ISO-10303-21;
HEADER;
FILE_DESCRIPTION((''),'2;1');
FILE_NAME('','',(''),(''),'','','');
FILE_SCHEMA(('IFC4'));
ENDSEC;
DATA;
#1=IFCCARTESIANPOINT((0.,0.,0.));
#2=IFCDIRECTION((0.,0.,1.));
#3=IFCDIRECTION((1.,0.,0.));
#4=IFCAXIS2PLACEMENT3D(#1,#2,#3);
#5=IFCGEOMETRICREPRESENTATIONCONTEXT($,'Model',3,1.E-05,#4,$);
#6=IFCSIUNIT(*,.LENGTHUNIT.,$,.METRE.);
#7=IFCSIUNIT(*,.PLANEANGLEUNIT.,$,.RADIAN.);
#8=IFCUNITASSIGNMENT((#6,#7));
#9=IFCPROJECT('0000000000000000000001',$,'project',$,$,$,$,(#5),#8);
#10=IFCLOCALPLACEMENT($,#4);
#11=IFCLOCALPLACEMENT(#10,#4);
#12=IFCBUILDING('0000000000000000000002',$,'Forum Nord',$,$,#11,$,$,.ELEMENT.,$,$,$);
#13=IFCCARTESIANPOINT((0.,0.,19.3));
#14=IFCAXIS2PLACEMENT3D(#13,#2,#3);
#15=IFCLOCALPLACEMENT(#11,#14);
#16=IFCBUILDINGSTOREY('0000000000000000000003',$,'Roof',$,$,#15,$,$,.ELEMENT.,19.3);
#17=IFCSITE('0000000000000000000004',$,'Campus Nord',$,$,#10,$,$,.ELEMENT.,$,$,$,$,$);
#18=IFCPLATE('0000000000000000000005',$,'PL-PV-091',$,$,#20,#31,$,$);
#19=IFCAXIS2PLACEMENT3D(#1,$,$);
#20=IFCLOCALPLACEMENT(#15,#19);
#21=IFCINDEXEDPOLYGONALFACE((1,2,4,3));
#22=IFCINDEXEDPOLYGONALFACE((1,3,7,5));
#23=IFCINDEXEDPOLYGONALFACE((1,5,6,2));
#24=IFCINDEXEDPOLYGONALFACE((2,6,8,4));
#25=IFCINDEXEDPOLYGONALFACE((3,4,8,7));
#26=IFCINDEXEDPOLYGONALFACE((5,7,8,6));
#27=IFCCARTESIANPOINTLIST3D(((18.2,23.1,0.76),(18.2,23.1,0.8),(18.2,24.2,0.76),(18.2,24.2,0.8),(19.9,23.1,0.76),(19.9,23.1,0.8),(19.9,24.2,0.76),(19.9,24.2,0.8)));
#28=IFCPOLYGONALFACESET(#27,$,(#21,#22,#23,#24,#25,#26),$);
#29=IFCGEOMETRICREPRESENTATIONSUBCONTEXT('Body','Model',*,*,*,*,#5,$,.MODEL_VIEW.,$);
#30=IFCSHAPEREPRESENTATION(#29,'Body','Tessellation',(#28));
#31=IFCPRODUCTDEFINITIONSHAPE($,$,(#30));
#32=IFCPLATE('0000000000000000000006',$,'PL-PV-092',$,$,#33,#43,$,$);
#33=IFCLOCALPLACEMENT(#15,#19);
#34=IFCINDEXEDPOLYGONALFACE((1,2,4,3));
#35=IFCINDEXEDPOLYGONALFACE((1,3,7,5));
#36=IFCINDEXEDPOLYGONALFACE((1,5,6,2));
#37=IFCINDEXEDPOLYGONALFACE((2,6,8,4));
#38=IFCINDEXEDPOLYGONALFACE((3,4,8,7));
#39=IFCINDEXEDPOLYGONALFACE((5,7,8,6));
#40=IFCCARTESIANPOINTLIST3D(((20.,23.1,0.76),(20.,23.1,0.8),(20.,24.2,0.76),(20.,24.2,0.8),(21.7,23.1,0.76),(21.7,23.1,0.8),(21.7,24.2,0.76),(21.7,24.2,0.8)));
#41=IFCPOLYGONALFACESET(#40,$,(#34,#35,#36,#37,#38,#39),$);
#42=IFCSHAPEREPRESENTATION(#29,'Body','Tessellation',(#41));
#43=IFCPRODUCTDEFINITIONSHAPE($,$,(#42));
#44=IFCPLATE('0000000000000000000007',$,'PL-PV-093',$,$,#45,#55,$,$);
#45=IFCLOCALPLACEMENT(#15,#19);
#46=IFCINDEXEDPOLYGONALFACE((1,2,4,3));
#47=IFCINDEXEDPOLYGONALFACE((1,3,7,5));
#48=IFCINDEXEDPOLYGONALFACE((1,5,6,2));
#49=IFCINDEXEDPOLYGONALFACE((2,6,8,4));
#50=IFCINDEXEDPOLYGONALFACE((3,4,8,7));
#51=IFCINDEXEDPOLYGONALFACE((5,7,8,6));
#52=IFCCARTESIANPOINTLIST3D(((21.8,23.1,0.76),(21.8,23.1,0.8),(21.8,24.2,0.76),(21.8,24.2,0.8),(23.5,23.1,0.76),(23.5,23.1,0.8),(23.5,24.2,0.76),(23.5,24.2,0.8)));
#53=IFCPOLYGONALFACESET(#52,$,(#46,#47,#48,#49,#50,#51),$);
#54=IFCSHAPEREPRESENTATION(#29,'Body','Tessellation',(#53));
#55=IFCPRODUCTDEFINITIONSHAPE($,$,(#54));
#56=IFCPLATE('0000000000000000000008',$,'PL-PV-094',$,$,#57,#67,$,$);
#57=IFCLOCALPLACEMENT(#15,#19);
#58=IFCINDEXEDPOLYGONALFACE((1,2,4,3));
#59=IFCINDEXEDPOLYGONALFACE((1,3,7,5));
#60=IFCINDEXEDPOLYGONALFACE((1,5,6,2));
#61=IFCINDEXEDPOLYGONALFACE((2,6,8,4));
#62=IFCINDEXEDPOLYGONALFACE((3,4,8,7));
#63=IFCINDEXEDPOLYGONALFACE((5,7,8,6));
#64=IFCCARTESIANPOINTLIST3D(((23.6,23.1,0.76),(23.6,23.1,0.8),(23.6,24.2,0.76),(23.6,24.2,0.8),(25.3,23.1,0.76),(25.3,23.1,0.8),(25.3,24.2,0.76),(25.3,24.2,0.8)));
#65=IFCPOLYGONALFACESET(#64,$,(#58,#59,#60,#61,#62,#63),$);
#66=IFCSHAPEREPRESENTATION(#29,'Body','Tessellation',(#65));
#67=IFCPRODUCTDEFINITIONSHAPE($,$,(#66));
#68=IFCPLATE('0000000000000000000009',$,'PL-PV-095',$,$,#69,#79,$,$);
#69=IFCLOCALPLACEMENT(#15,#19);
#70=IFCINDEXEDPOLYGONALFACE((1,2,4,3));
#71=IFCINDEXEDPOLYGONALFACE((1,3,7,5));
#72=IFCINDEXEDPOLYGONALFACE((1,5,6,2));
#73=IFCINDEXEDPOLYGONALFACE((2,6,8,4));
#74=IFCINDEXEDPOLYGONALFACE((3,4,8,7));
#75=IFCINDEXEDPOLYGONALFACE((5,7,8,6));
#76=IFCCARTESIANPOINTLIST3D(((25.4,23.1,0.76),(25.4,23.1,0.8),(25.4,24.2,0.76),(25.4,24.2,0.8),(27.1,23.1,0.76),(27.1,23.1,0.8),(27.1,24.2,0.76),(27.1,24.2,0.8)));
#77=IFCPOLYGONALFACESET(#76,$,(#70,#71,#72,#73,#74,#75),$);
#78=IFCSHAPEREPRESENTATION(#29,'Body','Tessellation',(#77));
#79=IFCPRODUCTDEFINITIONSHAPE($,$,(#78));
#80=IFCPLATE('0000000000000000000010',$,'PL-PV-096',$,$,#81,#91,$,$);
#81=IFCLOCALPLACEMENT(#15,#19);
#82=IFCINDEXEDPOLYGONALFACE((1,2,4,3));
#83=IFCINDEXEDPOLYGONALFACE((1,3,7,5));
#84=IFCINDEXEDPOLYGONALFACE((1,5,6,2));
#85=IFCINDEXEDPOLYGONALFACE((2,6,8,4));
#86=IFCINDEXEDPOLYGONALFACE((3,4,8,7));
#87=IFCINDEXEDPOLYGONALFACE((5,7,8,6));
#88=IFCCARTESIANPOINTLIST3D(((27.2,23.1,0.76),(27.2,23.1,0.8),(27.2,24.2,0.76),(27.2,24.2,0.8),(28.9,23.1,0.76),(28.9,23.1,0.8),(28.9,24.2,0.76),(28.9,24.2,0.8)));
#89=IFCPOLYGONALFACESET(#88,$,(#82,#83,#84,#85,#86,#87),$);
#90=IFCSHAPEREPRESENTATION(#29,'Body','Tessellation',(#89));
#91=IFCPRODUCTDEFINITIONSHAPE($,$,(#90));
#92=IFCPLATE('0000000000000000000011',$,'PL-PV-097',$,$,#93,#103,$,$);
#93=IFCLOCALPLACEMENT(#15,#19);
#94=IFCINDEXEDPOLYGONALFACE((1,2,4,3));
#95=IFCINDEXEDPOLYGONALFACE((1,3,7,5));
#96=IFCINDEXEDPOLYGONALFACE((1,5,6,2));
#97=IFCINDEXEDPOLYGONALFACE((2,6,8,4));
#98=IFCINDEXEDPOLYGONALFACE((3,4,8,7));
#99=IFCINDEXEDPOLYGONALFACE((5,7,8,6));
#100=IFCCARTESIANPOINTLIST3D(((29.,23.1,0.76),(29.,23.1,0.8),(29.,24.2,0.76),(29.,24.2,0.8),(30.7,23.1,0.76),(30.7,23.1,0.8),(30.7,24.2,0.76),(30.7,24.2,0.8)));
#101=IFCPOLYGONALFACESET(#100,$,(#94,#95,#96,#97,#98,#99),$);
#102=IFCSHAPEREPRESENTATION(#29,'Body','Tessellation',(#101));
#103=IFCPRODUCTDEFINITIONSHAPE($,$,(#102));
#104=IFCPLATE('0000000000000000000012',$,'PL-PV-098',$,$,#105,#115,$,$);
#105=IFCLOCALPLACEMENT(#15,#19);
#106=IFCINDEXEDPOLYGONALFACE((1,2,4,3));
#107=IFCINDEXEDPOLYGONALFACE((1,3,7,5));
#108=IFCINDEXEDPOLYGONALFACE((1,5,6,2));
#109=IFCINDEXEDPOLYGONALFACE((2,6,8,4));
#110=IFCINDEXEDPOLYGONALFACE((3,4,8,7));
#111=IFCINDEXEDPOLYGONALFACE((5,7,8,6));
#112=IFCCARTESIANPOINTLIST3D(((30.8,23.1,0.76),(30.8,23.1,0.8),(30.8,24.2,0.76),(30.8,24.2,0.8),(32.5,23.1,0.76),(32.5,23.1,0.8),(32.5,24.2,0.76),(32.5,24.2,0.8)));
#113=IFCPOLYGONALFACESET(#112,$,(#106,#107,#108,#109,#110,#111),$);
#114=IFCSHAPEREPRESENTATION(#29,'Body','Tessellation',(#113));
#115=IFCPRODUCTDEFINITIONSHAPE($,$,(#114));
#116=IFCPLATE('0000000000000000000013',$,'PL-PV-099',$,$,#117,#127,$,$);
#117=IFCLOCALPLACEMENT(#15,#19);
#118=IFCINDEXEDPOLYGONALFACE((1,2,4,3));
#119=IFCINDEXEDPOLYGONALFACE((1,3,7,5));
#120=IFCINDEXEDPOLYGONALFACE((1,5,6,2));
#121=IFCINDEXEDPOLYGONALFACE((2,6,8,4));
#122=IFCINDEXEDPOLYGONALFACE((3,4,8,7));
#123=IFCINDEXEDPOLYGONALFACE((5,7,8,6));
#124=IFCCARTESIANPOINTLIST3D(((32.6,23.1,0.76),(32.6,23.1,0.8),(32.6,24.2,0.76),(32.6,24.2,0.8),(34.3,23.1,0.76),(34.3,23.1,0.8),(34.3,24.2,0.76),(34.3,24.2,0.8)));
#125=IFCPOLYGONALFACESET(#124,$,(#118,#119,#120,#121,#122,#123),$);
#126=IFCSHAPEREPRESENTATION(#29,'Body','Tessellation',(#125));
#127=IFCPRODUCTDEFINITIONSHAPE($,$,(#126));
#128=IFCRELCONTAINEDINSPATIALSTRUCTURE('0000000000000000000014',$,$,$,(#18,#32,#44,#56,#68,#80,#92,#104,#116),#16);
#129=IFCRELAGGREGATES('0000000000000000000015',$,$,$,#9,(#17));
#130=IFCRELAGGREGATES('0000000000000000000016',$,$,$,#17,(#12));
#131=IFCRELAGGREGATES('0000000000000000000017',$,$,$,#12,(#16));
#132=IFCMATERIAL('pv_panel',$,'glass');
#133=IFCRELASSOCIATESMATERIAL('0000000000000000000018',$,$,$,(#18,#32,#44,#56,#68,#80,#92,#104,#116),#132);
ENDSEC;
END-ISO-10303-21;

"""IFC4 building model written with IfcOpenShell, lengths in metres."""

from ifc_helpers import new_model, si_unit, frame, origin_with_axes, place, context, subcontext, project, spatial, polyline, outline, extrude, material, element, save


model = new_model("IFC4")

# Units and contexts
model_context = context("Model", 3, precision=1e-05, world=origin_with_axes())
body_context = subcontext(model_context, "Body", "Model", "MODEL_VIEW")
ifc_project = project(units=[si_unit("LENGTHUNIT", "METRE"), si_unit("PLANEANGLEUNIT", "RADIAN")], contexts=[model_context])

# Site, building, storey
site_placement = place(None, origin_with_axes())
site = spatial("IfcSite", under=ifc_project, at=site_placement, Name="Campus Nord", CompositionType="ELEMENT")
building_placement = place(site_placement, origin_with_axes())
building = spatial("IfcBuilding", under=site, at=building_placement, Name="Forum Nord", CompositionType="ELEMENT")
storey_placement = place(building_placement, frame((0.0, 0.0, 19.3), z_axis=(0.0, 0.0, 1.0), x_axis=(1.0, 0.0, 0.0)))
storey = spatial("IfcBuildingStorey", under=building, at=storey_placement, Name="Roof", CompositionType="ELEMENT", Elevation=19.3)

# Plates
ifc_material_1 = material(Name="pv_panel", Category="glass")
plate_1_placement = place(storey_placement, frame((0.0, 0.0, 0.8), z_axis=(0.0, 0.0, 1.0), x_axis=(1.0, 0.0, 0.0)))
element("IfcPlate", 1, at=plate_1_placement, inside=storey, material=ifc_material_1, Name="PL-PV-091", context=body_context, shape_type="SweptSolid", body=[
    extrude(outline(polyline([(18.2, 23.1), (19.9, 23.1), (19.9, 24.2), (18.2, 24.2), (18.2, 23.1)])), frame((0.0, 0.0, -0.04), z_axis=(0.0, 0.0, 1.0), x_axis=(1.0, 0.0, 0.0)), (0.0, 0.0, 1.0), 0.04),
])
plate_2_placement = place(storey_placement, frame((0.0, 0.0, 0.8), z_axis=(0.0, 0.0, 1.0), x_axis=(1.0, 0.0, 0.0)))
element("IfcPlate", 2, at=plate_2_placement, inside=storey, material=ifc_material_1, Name="PL-PV-092", context=body_context, shape_type="SweptSolid", body=[
    extrude(outline(polyline([(20.0, 23.1), (21.7, 23.1), (21.7, 24.2), (20.0, 24.2), (20.0, 23.1)])), frame((0.0, 0.0, -0.04), z_axis=(0.0, 0.0, 1.0), x_axis=(1.0, 0.0, 0.0)), (0.0, 0.0, 1.0), 0.04),
])
plate_3_placement = place(storey_placement, frame((0.0, 0.0, 0.8), z_axis=(0.0, 0.0, 1.0), x_axis=(1.0, 0.0, 0.0)))
element("IfcPlate", 3, at=plate_3_placement, inside=storey, material=ifc_material_1, Name="PL-PV-093", context=body_context, shape_type="SweptSolid", body=[
    extrude(outline(polyline([(21.8, 23.1), (23.5, 23.1), (23.5, 24.2), (21.8, 24.2), (21.8, 23.1)])), frame((0.0, 0.0, -0.04), z_axis=(0.0, 0.0, 1.0), x_axis=(1.0, 0.0, 0.0)), (0.0, 0.0, 1.0), 0.04),
])
plate_4_placement = place(storey_placement, frame((0.0, 0.0, 0.8), z_axis=(0.0, 0.0, 1.0), x_axis=(1.0, 0.0, 0.0)))
element("IfcPlate", 4, at=plate_4_placement, inside=storey, material=ifc_material_1, Name="PL-PV-094", context=body_context, shape_type="SweptSolid", body=[
    extrude(outline(polyline([(23.6, 23.1), (25.3, 23.1), (25.3, 24.2), (23.6, 24.2), (23.6, 23.1)])), frame((0.0, 0.0, -0.04), z_axis=(0.0, 0.0, 1.0), x_axis=(1.0, 0.0, 0.0)), (0.0, 0.0, 1.0), 0.04),
])
plate_5_placement = place(storey_placement, frame((0.0, 0.0, 0.8), z_axis=(0.0, 0.0, 1.0), x_axis=(1.0, 0.0, 0.0)))
element("IfcPlate", 5, at=plate_5_placement, inside=storey, material=ifc_material_1, Name="PL-PV-095", context=body_context, shape_type="SweptSolid", body=[
    extrude(outline(polyline([(25.4, 23.1), (27.1, 23.1), (27.1, 24.2), (25.4, 24.2), (25.4, 23.1)])), frame((0.0, 0.0, -0.04), z_axis=(0.0, 0.0, 1.0), x_axis=(1.0, 0.0, 0.0)), (0.0, 0.0, 1.0), 0.04),
])
plate_6_placement = place(storey_placement, frame((0.0, 0.0, 0.8), z_axis=(0.0, 0.0, 1.0), x_axis=(1.0, 0.0, 0.0)))
element("IfcPlate", 6, at=plate_6_placement, inside=storey, material=ifc_material_1, Name="PL-PV-096", context=body_context, shape_type="SweptSolid", body=[
    extrude(outline(polyline([(27.2, 23.1), (28.9, 23.1), (28.9, 24.2), (27.2, 24.2), (27.2, 23.1)])), frame((0.0, 0.0, -0.04), z_axis=(0.0, 0.0, 1.0), x_axis=(1.0, 0.0, 0.0)), (0.0, 0.0, 1.0), 0.04),
])
plate_7_placement = place(storey_placement, frame((0.0, 0.0, 0.8), z_axis=(0.0, 0.0, 1.0), x_axis=(1.0, 0.0, 0.0)))
element("IfcPlate", 7, at=plate_7_placement, inside=storey, material=ifc_material_1, Name="PL-PV-097", context=body_context, shape_type="SweptSolid", body=[
    extrude(outline(polyline([(29.0, 23.1), (30.7, 23.1), (30.7, 24.2), (29.0, 24.2), (29.0, 23.1)])), frame((0.0, 0.0, -0.04), z_axis=(0.0, 0.0, 1.0), x_axis=(1.0, 0.0, 0.0)), (0.0, 0.0, 1.0), 0.04),
])
plate_8_placement = place(storey_placement, frame((0.0, 0.0, 0.8), z_axis=(0.0, 0.0, 1.0), x_axis=(1.0, 0.0, 0.0)))
element("IfcPlate", 8, at=plate_8_placement, inside=storey, material=ifc_material_1, Name="PL-PV-098", context=body_context, shape_type="SweptSolid", body=[
    extrude(outline(polyline([(30.8, 23.1), (32.5, 23.1), (32.5, 24.2), (30.8, 24.2), (30.8, 23.1)])), frame((0.0, 0.0, -0.04), z_axis=(0.0, 0.0, 1.0), x_axis=(1.0, 0.0, 0.0)), (0.0, 0.0, 1.0), 0.04),
])
plate_9_placement = place(storey_placement, frame((0.0, 0.0, 0.8), z_axis=(0.0, 0.0, 1.0), x_axis=(1.0, 0.0, 0.0)))
element("IfcPlate", 9, at=plate_9_placement, inside=storey, material=ifc_material_1, Name="PL-PV-099", context=body_context, shape_type="SweptSolid", body=[
    extrude(outline(polyline([(32.6, 23.1), (34.3, 23.1), (34.3, 24.2), (32.6, 24.2), (32.6, 23.1)])), frame((0.0, 0.0, -0.04), z_axis=(0.0, 0.0, 1.0), x_axis=(1.0, 0.0, 0.0)), (0.0, 0.0, 1.0), 0.04),
])

save(model, "model.ifc")
